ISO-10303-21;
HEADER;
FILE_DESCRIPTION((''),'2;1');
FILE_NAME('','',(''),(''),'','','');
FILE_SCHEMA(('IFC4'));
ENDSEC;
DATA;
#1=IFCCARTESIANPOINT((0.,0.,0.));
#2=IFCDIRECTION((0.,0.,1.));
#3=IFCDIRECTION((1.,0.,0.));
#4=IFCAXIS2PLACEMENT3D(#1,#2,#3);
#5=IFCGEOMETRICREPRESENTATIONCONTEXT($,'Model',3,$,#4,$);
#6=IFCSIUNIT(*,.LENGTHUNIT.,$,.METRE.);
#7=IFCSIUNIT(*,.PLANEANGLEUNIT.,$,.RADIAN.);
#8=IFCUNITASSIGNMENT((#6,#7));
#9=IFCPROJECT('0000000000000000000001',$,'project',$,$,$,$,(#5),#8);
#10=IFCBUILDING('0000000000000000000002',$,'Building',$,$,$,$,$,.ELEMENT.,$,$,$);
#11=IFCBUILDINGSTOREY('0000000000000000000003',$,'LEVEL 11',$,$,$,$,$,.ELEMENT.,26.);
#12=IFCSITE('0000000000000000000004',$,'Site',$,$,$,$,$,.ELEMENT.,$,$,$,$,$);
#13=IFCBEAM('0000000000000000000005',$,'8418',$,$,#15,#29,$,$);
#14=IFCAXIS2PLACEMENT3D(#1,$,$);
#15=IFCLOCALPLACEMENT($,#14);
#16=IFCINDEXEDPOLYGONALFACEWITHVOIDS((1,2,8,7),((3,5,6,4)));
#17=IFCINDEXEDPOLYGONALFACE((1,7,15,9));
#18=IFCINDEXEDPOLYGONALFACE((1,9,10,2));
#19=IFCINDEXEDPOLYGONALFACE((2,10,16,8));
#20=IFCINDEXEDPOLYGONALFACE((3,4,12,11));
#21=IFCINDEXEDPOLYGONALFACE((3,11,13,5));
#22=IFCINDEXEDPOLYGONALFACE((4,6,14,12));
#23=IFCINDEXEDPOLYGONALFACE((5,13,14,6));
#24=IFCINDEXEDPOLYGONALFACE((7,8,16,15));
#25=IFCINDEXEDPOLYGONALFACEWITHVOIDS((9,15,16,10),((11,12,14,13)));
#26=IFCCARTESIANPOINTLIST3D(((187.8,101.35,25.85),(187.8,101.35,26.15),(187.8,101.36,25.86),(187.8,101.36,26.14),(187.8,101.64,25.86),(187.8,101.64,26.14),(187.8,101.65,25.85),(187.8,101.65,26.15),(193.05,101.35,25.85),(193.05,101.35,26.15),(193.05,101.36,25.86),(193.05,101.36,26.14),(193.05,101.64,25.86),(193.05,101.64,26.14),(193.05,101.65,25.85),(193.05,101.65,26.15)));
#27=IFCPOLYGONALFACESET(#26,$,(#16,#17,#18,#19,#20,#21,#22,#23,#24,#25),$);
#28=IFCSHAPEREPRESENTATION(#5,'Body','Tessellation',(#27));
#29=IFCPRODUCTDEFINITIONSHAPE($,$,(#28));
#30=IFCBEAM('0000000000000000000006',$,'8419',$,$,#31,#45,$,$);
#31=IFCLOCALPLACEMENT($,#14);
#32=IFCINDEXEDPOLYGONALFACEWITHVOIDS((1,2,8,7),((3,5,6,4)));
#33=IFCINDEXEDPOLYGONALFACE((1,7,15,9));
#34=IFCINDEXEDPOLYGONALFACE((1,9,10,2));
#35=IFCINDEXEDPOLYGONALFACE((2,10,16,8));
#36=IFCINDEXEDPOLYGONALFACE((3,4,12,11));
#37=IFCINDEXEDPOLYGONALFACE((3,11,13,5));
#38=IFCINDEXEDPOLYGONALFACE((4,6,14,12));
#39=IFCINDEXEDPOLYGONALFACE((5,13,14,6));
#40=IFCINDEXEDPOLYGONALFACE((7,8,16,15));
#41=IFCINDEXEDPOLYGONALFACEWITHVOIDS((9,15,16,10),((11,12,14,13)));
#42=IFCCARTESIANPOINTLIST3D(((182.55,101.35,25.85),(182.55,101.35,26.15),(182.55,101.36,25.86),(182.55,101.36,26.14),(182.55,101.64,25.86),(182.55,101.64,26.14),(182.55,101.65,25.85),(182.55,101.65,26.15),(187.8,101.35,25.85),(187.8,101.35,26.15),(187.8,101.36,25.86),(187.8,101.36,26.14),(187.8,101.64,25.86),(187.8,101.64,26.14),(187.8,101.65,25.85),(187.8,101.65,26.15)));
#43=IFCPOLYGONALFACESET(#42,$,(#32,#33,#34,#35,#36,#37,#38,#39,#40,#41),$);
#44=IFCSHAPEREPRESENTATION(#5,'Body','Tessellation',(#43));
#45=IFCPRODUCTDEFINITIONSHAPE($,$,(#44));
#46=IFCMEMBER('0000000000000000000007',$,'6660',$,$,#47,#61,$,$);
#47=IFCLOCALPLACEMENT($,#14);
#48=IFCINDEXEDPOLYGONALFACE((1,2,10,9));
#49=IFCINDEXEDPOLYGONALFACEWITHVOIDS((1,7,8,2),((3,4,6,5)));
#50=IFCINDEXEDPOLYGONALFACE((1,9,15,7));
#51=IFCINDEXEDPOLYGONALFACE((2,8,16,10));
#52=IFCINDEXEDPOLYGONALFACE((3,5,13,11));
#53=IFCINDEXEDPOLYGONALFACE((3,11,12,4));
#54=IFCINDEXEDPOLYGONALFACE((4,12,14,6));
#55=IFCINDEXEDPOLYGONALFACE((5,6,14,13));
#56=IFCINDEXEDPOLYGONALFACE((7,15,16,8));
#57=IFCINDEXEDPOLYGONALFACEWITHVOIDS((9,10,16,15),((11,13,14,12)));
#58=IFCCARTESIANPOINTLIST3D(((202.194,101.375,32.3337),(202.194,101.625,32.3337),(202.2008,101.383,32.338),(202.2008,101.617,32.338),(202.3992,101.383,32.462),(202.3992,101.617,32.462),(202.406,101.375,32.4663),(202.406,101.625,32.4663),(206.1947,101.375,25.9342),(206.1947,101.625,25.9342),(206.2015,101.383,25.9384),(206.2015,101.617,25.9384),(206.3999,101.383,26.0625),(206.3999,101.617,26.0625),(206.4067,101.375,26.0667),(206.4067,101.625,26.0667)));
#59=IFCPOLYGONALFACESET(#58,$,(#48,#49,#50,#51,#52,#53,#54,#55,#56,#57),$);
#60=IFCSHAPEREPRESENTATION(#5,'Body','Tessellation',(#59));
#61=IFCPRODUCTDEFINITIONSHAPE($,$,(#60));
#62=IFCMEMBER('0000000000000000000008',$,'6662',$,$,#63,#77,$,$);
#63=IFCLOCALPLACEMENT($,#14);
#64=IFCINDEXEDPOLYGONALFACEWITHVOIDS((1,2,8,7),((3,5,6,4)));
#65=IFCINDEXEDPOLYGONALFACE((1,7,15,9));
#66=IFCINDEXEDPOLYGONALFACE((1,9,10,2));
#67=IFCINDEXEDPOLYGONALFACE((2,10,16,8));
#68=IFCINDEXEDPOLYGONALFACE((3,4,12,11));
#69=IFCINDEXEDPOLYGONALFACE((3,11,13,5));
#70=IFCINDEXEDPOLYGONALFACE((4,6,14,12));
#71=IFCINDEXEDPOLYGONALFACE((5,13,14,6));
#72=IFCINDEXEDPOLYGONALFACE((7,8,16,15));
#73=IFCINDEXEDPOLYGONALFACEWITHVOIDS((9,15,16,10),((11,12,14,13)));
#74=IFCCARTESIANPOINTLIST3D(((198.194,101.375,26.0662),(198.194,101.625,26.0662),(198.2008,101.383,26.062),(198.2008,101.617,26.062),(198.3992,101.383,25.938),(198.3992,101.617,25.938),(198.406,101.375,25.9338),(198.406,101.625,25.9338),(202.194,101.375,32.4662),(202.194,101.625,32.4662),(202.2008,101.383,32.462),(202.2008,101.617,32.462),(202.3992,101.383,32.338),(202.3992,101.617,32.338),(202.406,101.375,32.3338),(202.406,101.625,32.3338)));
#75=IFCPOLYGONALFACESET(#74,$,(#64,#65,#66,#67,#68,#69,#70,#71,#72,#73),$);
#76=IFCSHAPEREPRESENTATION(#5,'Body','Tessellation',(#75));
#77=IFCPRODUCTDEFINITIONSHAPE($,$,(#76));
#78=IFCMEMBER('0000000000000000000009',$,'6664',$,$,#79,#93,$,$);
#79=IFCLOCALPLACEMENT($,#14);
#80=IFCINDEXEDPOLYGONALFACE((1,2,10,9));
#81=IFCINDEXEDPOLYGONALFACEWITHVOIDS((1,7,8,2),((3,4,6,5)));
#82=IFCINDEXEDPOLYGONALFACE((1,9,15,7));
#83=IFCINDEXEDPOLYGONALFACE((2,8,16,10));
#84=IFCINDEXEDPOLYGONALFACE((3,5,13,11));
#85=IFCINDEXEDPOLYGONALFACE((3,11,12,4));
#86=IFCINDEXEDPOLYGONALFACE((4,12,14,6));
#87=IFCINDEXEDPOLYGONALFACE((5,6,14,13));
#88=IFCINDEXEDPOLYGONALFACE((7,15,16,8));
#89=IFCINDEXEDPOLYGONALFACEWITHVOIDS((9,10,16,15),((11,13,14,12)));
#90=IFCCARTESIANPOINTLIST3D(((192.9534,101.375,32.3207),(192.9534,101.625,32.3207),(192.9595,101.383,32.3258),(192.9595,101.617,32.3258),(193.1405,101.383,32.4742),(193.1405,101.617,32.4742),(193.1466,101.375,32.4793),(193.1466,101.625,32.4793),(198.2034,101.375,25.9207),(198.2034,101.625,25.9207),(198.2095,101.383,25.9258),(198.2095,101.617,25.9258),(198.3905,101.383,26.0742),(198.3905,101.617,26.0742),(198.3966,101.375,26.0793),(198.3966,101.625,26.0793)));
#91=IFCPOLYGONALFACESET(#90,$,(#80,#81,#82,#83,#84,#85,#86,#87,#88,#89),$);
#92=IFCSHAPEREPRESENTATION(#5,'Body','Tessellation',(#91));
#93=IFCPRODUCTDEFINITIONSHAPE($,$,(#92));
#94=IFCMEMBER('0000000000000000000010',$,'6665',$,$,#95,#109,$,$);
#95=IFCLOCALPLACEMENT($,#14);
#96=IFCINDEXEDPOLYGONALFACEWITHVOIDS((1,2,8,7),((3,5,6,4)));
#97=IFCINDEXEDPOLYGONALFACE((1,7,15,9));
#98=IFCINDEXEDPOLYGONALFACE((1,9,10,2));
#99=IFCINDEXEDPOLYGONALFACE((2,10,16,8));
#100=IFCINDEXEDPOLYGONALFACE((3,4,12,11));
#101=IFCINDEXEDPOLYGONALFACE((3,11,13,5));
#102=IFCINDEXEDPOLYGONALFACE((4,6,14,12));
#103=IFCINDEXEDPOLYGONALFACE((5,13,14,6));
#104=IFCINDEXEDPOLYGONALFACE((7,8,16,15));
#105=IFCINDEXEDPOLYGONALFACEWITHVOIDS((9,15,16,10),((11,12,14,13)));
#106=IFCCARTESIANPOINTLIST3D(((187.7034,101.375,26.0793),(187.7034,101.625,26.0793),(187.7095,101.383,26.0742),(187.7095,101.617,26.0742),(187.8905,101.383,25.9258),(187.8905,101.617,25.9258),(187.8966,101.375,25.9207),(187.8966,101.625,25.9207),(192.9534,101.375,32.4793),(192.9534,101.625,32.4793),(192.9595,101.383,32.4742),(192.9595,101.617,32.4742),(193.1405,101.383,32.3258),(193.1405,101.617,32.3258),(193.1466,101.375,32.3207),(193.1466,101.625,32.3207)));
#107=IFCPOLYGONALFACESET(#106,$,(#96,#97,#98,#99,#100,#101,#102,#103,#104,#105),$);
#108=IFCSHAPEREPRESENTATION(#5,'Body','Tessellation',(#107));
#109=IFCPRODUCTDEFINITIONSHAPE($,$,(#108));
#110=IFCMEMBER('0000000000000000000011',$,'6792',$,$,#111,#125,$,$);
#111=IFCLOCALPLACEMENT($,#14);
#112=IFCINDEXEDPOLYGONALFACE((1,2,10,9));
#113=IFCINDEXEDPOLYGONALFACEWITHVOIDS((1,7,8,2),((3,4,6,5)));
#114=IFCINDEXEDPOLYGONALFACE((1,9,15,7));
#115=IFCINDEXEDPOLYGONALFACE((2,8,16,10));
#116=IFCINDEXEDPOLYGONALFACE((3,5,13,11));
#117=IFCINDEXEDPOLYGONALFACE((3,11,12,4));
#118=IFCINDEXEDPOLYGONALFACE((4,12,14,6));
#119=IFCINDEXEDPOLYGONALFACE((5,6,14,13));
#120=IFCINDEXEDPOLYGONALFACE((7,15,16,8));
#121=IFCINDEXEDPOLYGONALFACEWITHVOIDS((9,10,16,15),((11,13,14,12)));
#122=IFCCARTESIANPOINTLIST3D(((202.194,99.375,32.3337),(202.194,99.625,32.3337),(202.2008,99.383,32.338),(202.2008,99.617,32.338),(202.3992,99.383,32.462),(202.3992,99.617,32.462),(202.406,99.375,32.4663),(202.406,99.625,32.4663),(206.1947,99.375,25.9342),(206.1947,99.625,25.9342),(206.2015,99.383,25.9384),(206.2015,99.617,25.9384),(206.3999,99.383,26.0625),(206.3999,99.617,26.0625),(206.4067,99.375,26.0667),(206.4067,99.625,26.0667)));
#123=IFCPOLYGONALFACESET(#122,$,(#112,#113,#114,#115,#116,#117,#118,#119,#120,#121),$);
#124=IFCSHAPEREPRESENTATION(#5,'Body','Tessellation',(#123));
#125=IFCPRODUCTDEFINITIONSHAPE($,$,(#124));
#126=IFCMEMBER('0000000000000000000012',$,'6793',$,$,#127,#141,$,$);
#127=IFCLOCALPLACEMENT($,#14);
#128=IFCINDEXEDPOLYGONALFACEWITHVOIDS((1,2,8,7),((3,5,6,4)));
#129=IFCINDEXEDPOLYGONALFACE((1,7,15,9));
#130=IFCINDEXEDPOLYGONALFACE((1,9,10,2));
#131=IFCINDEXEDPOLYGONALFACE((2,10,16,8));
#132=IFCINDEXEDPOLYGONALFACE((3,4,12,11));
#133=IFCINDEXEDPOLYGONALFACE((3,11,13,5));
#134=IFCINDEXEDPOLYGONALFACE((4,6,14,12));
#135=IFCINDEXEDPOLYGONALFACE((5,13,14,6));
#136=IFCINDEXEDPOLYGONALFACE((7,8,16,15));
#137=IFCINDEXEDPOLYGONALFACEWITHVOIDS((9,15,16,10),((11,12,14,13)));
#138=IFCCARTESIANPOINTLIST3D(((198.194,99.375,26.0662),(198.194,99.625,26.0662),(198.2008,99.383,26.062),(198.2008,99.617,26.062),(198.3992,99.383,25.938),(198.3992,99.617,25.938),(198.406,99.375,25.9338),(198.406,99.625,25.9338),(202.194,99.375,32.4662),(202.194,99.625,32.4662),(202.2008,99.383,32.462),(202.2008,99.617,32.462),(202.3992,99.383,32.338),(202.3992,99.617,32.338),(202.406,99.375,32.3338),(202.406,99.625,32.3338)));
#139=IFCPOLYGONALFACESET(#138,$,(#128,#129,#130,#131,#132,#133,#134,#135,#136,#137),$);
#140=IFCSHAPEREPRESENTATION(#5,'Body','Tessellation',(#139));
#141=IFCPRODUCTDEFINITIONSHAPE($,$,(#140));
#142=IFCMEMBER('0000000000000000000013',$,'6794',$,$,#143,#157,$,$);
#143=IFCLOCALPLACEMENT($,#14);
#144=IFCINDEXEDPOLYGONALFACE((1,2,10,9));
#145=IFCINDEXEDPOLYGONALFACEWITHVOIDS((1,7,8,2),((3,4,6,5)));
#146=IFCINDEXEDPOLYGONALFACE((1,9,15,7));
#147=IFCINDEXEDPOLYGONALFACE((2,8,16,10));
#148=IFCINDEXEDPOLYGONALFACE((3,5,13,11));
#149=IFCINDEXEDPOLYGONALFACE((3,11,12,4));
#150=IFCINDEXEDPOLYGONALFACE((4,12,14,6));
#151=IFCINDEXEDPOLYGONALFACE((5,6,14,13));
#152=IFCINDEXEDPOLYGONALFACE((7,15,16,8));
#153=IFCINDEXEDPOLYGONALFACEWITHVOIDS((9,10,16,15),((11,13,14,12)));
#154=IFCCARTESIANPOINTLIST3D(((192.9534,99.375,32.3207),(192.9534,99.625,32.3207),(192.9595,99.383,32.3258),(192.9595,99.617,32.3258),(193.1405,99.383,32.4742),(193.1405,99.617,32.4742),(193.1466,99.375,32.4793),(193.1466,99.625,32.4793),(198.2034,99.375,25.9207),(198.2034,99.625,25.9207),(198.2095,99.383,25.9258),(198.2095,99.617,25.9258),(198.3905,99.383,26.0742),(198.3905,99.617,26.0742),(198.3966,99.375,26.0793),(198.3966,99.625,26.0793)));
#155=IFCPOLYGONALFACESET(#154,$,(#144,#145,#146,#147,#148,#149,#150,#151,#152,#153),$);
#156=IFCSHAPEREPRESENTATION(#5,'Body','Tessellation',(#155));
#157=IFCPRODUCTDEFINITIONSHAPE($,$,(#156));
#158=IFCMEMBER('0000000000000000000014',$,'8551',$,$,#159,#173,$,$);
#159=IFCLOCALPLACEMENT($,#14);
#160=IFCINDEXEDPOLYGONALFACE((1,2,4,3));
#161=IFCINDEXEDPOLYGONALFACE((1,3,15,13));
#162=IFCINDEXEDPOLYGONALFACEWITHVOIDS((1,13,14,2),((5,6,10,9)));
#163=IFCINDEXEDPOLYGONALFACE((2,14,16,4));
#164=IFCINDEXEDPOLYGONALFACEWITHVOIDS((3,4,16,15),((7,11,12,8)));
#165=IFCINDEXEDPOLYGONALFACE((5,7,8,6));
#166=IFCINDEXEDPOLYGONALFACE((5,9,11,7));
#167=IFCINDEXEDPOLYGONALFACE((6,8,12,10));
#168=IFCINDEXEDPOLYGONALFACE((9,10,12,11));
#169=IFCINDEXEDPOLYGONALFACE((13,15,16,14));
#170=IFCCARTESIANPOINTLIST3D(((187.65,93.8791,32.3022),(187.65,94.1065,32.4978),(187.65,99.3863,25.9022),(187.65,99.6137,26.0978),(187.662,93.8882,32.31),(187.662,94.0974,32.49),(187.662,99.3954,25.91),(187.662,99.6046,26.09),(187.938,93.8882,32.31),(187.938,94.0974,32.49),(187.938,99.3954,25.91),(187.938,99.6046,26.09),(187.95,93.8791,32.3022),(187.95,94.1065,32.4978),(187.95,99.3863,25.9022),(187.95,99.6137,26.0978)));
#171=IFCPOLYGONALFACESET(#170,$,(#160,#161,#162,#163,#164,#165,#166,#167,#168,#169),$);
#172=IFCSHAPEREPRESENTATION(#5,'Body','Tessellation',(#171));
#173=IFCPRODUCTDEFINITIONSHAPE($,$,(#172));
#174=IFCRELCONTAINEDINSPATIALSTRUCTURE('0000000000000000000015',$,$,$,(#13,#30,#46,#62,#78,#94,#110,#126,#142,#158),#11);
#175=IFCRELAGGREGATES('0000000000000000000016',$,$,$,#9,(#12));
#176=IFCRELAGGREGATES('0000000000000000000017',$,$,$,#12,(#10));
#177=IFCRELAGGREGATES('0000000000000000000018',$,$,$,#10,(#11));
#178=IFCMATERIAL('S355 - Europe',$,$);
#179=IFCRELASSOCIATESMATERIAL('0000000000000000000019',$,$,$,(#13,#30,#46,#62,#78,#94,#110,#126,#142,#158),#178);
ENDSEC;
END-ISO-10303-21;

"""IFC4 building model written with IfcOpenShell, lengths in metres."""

from ifc_helpers import new_model, si_unit, frame, origin_with_axes, origin_2d_with_axis, place, context, project, spatial, hollow_rectangle, extrude, material, material_profile, profile_set, profile_usage, element, save


model = new_model("IFC4")

# Units and contexts
model_context = context("Model", 3, world=origin_with_axes())
ifc_project = project(units=[si_unit("LENGTHUNIT", "METRE"), si_unit("PLANEANGLEUNIT", "RADIAN")], contexts=[model_context])

# Site, building, storey
site = spatial("IfcSite", under=ifc_project, Name="Site", CompositionType="ELEMENT")
building = spatial("IfcBuilding", under=site, Name="Building", CompositionType="ELEMENT")
storey = spatial("IfcBuildingStorey", under=building, Name="LEVEL 11", CompositionType="ELEMENT", Elevation=26.0)

# Shared definitions
ifc_material = material(Name="S355 - Europe")

# Beams
ifc_material_profile_1 = material_profile(ifc_material, hollow_rectangle(XDim=0.3, YDim=0.3, WallThickness=0.01, at=origin_2d_with_axis()))
ifc_profile_set_1 = profile_set([ifc_material_profile_1])
ifc_profile_usage_1 = profile_usage(ifc_profile_set_1, cardinal=10)
beam_1_placement = place(None, frame((193.05, 101.5, 26.0), z_axis=(-1.0, 0.0, 0.0), x_axis=(0.0, -1.0, 0.0)))
element("IfcBeam", 1, at=beam_1_placement, inside=storey, material=ifc_profile_usage_1, Name="8418", context=model_context, shape_type="SweptSolid", body=[
    extrude(hollow_rectangle(XDim=0.3, YDim=0.3, WallThickness=0.01, at=origin_2d_with_axis()), origin_with_axes(), (0.0, 0.0, 1.0), 5.25),
])
ifc_material_profile_2 = material_profile(ifc_material, hollow_rectangle(XDim=0.3, YDim=0.3, WallThickness=0.01, at=origin_2d_with_axis()))
ifc_profile_set_2 = profile_set([ifc_material_profile_2])
ifc_profile_usage_2 = profile_usage(ifc_profile_set_2, cardinal=10)
beam_2_placement = place(None, frame((187.8, 101.5, 26.0), z_axis=(-1.0, 0.0, 0.0), x_axis=(0.0, -1.0, 0.0)))
element("IfcBeam", 2, at=beam_2_placement, inside=storey, material=ifc_profile_usage_2, Name="8419", context=model_context, shape_type="SweptSolid", body=[
    extrude(hollow_rectangle(XDim=0.3, YDim=0.3, WallThickness=0.01, at=origin_2d_with_axis()), origin_with_axes(), (0.0, 0.0, 1.0), 5.25),
])

# Members
ifc_material_profile_3 = material_profile(ifc_material, hollow_rectangle(XDim=0.25, YDim=0.25, WallThickness=0.008, at=origin_2d_with_axis()))
ifc_profile_set_3 = profile_set([ifc_material_profile_3])
ifc_profile_usage_3 = profile_usage(ifc_profile_set_3, cardinal=10)
member_1_placement = place(None, frame((202.3, 101.5, 32.4), z_axis=(0.530094, 0.0, -0.847939), x_axis=(0.0, 1.0, 0.0)))
element("IfcMember", 3, at=member_1_placement, inside=storey, material=ifc_profile_usage_3, Name="6660", context=model_context, shape_type="SweptSolid", body=[
    extrude(hollow_rectangle(XDim=0.25, YDim=0.25, WallThickness=0.008, at=origin_2d_with_axis()), origin_with_axes(), (0.0, 0.0, 1.0), 7.5472),
])
ifc_material_profile_4 = material_profile(ifc_material, hollow_rectangle(XDim=0.25, YDim=0.25, WallThickness=0.008, at=origin_2d_with_axis()))
ifc_profile_set_4 = profile_set([ifc_material_profile_4])
ifc_profile_usage_4 = profile_usage(ifc_profile_set_4, cardinal=10)
member_2_placement = place(None, frame((198.3, 101.5, 26.0), z_axis=(0.529999, 0.0, 0.847998), x_axis=(0.0, 1.0, 0.0)))
element("IfcMember", 4, at=member_2_placement, inside=storey, material=ifc_profile_usage_4, Name="6662", context=model_context, shape_type="SweptSolid", body=[
    extrude(hollow_rectangle(XDim=0.25, YDim=0.25, WallThickness=0.008, at=origin_2d_with_axis()), origin_with_axes(), (0.0, 0.0, 1.0), 7.5472),
])
ifc_material_profile_5 = material_profile(ifc_material, hollow_rectangle(XDim=0.25, YDim=0.25, WallThickness=0.008, at=origin_2d_with_axis()))
ifc_profile_set_5 = profile_set([ifc_material_profile_5])
ifc_profile_usage_5 = profile_usage(ifc_profile_set_5, cardinal=10)
member_3_placement = place(None, frame((193.05, 101.5, 32.4), z_axis=(0.634224, 0.0, -0.773149), x_axis=(0.0, 1.0, 0.0)))
element("IfcMember", 5, at=member_3_placement, inside=storey, material=ifc_profile_usage_5, Name="6664", context=model_context, shape_type="SweptSolid", body=[
    extrude(hollow_rectangle(XDim=0.25, YDim=0.25, WallThickness=0.008, at=origin_2d_with_axis()), origin_with_axes(), (0.0, 0.0, 1.0), 8.2778),
])
ifc_material_profile_6 = material_profile(ifc_material, hollow_rectangle(XDim=0.25, YDim=0.25, WallThickness=0.008, at=origin_2d_with_axis()))
ifc_profile_set_6 = profile_set([ifc_material_profile_6])
ifc_profile_usage_6 = profile_usage(ifc_profile_set_6, cardinal=10)
member_4_placement = place(None, frame((187.8, 101.5, 26.0), z_axis=(0.634224, 0.0, 0.773149), x_axis=(0.0, 1.0, 0.0)))
element("IfcMember", 6, at=member_4_placement, inside=storey, material=ifc_profile_usage_6, Name="6665", context=model_context, shape_type="SweptSolid", body=[
    extrude(hollow_rectangle(XDim=0.25, YDim=0.25, WallThickness=0.008, at=origin_2d_with_axis()), origin_with_axes(), (0.0, 0.0, 1.0), 8.2778),
])
ifc_material_profile_7 = material_profile(ifc_material, hollow_rectangle(XDim=0.25, YDim=0.25, WallThickness=0.008, at=origin_2d_with_axis()))
ifc_profile_set_7 = profile_set([ifc_material_profile_7])
ifc_profile_usage_7 = profile_usage(ifc_profile_set_7, cardinal=10)
member_5_placement = place(None, frame((202.3, 99.5, 32.4), z_axis=(0.530094, 0.0, -0.847939), x_axis=(0.0, 1.0, 0.0)))
element("IfcMember", 7, at=member_5_placement, inside=storey, material=ifc_profile_usage_7, Name="6792", context=model_context, shape_type="SweptSolid", body=[
    extrude(hollow_rectangle(XDim=0.25, YDim=0.25, WallThickness=0.008, at=origin_2d_with_axis()), origin_with_axes(), (0.0, 0.0, 1.0), 7.5472),
])
ifc_material_profile_8 = material_profile(ifc_material, hollow_rectangle(XDim=0.25, YDim=0.25, WallThickness=0.008, at=origin_2d_with_axis()))
ifc_profile_set_8 = profile_set([ifc_material_profile_8])
ifc_profile_usage_8 = profile_usage(ifc_profile_set_8, cardinal=10)
member_6_placement = place(None, frame((198.3, 99.5, 26.0), z_axis=(0.529999, 0.0, 0.847998), x_axis=(0.0, 1.0, 0.0)))
element("IfcMember", 8, at=member_6_placement, inside=storey, material=ifc_profile_usage_8, Name="6793", context=model_context, shape_type="SweptSolid", body=[
    extrude(hollow_rectangle(XDim=0.25, YDim=0.25, WallThickness=0.008, at=origin_2d_with_axis()), origin_with_axes(), (0.0, 0.0, 1.0), 7.5472),
])
ifc_material_profile_9 = material_profile(ifc_material, hollow_rectangle(XDim=0.25, YDim=0.25, WallThickness=0.008, at=origin_2d_with_axis()))
ifc_profile_set_9 = profile_set([ifc_material_profile_9])
ifc_profile_usage_9 = profile_usage(ifc_profile_set_9, cardinal=10)
member_7_placement = place(None, frame((193.05, 99.5, 32.4), z_axis=(0.634224, 0.0, -0.773149), x_axis=(0.0, 1.0, 0.0)))
element("IfcMember", 9, at=member_7_placement, inside=storey, material=ifc_profile_usage_9, Name="6794", context=model_context, shape_type="SweptSolid", body=[
    extrude(hollow_rectangle(XDim=0.25, YDim=0.25, WallThickness=0.008, at=origin_2d_with_axis()), origin_with_axes(), (0.0, 0.0, 1.0), 8.2778),
])
ifc_material_profile_10 = material_profile(ifc_material, hollow_rectangle(XDim=0.3, YDim=0.3, WallThickness=0.012, at=origin_2d_with_axis()))
ifc_profile_set_10 = profile_set([ifc_material_profile_10])
ifc_profile_usage_10 = profile_usage(ifc_profile_set_10, cardinal=10)
member_8_placement = place(None, frame((187.8, 99.5, 26.0), z_axis=(0.0, -0.652257, 0.757998), x_axis=(1.0, 0.0, 0.0)))
element("IfcMember", 10, at=member_8_placement, inside=storey, material=ifc_profile_usage_10, Name="8551", context=model_context, shape_type="SweptSolid", body=[
    extrude(hollow_rectangle(XDim=0.3, YDim=0.3, WallThickness=0.012, at=origin_2d_with_axis()), origin_with_axes(), (0.0, 0.0, 1.0), 8.4433),
])

save(model, "model.ifc")
